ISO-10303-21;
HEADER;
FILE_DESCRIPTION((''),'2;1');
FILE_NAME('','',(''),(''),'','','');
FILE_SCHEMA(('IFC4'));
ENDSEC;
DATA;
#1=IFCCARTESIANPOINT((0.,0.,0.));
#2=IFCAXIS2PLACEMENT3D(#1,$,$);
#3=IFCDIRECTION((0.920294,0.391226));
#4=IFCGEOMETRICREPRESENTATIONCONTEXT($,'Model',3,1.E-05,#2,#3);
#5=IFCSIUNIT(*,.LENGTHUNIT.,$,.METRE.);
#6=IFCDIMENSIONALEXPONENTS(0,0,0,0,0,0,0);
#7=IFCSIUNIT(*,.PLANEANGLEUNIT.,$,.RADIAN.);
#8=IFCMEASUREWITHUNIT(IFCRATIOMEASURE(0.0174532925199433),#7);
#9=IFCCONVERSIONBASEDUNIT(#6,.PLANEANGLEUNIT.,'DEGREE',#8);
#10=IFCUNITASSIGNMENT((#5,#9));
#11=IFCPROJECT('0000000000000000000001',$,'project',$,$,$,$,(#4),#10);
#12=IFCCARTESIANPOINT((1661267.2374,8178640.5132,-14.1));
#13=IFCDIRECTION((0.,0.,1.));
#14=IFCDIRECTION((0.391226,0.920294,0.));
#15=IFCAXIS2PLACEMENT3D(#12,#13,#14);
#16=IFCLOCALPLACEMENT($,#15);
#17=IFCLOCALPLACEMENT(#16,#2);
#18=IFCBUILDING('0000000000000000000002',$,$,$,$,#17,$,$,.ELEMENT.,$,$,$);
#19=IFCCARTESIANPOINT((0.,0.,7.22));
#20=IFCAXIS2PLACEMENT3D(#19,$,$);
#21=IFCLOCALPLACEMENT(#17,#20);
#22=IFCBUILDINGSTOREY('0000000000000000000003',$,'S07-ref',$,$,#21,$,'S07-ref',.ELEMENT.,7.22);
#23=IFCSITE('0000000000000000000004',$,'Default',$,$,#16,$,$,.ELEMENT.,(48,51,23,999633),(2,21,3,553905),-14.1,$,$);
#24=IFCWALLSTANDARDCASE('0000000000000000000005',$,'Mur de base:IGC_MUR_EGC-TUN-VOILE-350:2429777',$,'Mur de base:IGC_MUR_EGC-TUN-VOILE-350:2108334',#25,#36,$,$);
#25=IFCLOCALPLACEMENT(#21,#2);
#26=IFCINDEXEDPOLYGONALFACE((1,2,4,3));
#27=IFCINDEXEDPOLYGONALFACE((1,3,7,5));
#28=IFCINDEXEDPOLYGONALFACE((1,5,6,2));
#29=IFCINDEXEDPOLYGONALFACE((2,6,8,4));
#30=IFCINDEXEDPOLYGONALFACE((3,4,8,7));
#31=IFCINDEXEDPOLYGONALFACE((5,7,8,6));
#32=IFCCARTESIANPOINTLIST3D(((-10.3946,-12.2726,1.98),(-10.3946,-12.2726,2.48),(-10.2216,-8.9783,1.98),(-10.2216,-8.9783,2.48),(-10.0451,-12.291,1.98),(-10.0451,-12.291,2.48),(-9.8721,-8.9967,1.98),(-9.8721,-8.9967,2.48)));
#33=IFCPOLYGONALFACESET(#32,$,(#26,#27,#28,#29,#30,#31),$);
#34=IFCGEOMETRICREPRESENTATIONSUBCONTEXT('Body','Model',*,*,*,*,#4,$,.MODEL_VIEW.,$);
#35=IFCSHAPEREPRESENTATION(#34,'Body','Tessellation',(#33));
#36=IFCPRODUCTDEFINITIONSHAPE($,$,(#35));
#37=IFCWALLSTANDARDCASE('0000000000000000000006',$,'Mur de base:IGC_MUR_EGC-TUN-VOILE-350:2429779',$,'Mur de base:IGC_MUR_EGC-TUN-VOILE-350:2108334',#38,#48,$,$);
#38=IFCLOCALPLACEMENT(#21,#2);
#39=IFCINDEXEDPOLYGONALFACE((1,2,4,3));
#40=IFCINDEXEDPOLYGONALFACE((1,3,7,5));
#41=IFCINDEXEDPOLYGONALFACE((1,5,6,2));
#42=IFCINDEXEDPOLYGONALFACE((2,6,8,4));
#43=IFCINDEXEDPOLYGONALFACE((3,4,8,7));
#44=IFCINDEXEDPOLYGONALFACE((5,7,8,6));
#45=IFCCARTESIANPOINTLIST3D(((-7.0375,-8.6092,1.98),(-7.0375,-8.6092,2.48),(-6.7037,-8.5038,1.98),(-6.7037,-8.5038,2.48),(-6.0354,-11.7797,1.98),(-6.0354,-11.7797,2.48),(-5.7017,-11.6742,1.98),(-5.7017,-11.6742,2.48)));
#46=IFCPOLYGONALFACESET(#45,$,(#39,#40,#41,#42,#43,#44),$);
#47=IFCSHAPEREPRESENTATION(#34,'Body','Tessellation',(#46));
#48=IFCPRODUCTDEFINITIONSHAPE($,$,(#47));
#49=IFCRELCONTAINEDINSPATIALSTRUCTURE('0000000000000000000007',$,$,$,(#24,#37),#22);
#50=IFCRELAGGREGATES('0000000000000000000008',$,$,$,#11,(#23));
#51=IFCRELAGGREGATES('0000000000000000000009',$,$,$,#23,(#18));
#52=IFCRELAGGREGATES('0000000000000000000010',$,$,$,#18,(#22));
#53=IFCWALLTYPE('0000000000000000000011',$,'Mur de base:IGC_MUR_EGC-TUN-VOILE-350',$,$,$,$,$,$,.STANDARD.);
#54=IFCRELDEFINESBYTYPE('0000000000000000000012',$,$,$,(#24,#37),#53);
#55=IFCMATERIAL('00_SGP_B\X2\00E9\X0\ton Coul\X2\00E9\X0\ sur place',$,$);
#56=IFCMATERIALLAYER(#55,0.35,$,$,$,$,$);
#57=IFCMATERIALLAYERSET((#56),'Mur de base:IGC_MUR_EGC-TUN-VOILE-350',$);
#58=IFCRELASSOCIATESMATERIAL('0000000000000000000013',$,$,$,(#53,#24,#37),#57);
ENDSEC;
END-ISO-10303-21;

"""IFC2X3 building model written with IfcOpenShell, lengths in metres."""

from ifc_helpers import new_model, entity, si_unit, converted_unit, direction, frame, frame_2d, origin, place, context, subcontext, project, spatial, rectangle, extrude, material, layer, layer_set, layer_usage, type_object, element, save


model = new_model("IFC2X3")

# Units and contexts
model_context = context("Model", 3, precision=1e-05, world=origin(), true_north=direction((0.920294, 0.391226)))
body_context = subcontext(model_context, "Body", "Model", "MODEL_VIEW")
ifc_project = project(units=[si_unit("LENGTHUNIT", "METRE"), converted_unit("PLANEANGLEUNIT", "DEGREE", entity("IfcRatioMeasure", 0.0174532925199433), si_unit("PLANEANGLEUNIT", "RADIAN"), dimensions=[0, 0, 0, 0, 0, 0, 0])], contexts=[model_context])

# Site, building, storey
site_placement = place(None, frame((1661267.2374, 8178640.5132, -14.1), z_axis=(0.0, 0.0, 1.0), x_axis=(0.391226, 0.920294, 0.0)))
site = spatial("IfcSite", under=ifc_project, at=site_placement, Name="Default", CompositionType="ELEMENT", RefLatitude=(48, 51, 23, 999633), RefLongitude=(2, 21, 3, 553905), RefElevation=-14.1)
building_placement = place(site_placement, origin())
building = spatial("IfcBuilding", under=site, at=building_placement, CompositionType="ELEMENT")
storey_placement = place(building_placement, frame((0.0, 0.0, 7.22)))
storey = spatial("IfcBuildingStorey", under=building, at=storey_placement, Name="S07-ref", LongName="S07-ref", CompositionType="ELEMENT", Elevation=7.22)

# Walls
ifc_material_1 = material(Name="00_SGP_Béton Coulé sur place")
ifc_layer_1 = layer(ifc_material_1, 0.35)
ifc_layer_set_1 = layer_set([ifc_layer_1], Name="Mur de base:IGC_MUR_EGC-TUN-VOILE-350")
ifc_layer_usage_1 = layer_usage(ifc_layer_set_1, "AXIS2", "POSITIVE", -0.175)
wall_type_1 = type_object("IfcWallType", Name="Mur de base:IGC_MUR_EGC-TUN-VOILE-350", PredefinedType="STANDARD", material=ifc_layer_set_1)
wall_1_placement = place(storey_placement, frame((-10.0469, -8.9875, 1.98), z_axis=(0.0, 0.0, 1.0), x_axis=(-0.052435, -0.998624, 0.0)))
element("IfcWallStandardCase", 1, at=wall_1_placement, inside=storey, type_object=wall_type_1, material=ifc_layer_usage_1, Name="Mur de base:IGC_MUR_EGC-TUN-VOILE-350:2429777", ObjectType="Mur de base:IGC_MUR_EGC-TUN-VOILE-350:2108334", context=body_context, shape_type="SweptSolid", body=[
    extrude(rectangle(XDim=3.2988, YDim=0.35, at=frame_2d((1.6494, 0.0), x_axis=(-1.0, 0.0))), origin(), (0.0, 0.0, 1.0), 0.5),
])
ifc_layer_usage_2 = layer_usage(ifc_layer_set_1, "AXIS2", "POSITIVE", -0.175)
wall_2_placement = place(storey_placement, frame((-6.8706, -8.5565, 1.98), z_axis=(0.0, 0.0, 1.0), x_axis=(0.301365, -0.953509, 0.0)))
element("IfcWallStandardCase", 2, at=wall_2_placement, inside=storey, type_object=wall_type_1, material=ifc_layer_usage_2, Name="Mur de base:IGC_MUR_EGC-TUN-VOILE-350:2429779", ObjectType="Mur de base:IGC_MUR_EGC-TUN-VOILE-350:2108334", context=body_context, shape_type="SweptSolid", body=[
    extrude(rectangle(XDim=3.325, YDim=0.35, at=frame_2d((1.6625, 0.0), x_axis=(-1.0, 0.0))), origin(), (0.0, 0.0, 1.0), 0.5),
])

save(model, "model.ifc")
